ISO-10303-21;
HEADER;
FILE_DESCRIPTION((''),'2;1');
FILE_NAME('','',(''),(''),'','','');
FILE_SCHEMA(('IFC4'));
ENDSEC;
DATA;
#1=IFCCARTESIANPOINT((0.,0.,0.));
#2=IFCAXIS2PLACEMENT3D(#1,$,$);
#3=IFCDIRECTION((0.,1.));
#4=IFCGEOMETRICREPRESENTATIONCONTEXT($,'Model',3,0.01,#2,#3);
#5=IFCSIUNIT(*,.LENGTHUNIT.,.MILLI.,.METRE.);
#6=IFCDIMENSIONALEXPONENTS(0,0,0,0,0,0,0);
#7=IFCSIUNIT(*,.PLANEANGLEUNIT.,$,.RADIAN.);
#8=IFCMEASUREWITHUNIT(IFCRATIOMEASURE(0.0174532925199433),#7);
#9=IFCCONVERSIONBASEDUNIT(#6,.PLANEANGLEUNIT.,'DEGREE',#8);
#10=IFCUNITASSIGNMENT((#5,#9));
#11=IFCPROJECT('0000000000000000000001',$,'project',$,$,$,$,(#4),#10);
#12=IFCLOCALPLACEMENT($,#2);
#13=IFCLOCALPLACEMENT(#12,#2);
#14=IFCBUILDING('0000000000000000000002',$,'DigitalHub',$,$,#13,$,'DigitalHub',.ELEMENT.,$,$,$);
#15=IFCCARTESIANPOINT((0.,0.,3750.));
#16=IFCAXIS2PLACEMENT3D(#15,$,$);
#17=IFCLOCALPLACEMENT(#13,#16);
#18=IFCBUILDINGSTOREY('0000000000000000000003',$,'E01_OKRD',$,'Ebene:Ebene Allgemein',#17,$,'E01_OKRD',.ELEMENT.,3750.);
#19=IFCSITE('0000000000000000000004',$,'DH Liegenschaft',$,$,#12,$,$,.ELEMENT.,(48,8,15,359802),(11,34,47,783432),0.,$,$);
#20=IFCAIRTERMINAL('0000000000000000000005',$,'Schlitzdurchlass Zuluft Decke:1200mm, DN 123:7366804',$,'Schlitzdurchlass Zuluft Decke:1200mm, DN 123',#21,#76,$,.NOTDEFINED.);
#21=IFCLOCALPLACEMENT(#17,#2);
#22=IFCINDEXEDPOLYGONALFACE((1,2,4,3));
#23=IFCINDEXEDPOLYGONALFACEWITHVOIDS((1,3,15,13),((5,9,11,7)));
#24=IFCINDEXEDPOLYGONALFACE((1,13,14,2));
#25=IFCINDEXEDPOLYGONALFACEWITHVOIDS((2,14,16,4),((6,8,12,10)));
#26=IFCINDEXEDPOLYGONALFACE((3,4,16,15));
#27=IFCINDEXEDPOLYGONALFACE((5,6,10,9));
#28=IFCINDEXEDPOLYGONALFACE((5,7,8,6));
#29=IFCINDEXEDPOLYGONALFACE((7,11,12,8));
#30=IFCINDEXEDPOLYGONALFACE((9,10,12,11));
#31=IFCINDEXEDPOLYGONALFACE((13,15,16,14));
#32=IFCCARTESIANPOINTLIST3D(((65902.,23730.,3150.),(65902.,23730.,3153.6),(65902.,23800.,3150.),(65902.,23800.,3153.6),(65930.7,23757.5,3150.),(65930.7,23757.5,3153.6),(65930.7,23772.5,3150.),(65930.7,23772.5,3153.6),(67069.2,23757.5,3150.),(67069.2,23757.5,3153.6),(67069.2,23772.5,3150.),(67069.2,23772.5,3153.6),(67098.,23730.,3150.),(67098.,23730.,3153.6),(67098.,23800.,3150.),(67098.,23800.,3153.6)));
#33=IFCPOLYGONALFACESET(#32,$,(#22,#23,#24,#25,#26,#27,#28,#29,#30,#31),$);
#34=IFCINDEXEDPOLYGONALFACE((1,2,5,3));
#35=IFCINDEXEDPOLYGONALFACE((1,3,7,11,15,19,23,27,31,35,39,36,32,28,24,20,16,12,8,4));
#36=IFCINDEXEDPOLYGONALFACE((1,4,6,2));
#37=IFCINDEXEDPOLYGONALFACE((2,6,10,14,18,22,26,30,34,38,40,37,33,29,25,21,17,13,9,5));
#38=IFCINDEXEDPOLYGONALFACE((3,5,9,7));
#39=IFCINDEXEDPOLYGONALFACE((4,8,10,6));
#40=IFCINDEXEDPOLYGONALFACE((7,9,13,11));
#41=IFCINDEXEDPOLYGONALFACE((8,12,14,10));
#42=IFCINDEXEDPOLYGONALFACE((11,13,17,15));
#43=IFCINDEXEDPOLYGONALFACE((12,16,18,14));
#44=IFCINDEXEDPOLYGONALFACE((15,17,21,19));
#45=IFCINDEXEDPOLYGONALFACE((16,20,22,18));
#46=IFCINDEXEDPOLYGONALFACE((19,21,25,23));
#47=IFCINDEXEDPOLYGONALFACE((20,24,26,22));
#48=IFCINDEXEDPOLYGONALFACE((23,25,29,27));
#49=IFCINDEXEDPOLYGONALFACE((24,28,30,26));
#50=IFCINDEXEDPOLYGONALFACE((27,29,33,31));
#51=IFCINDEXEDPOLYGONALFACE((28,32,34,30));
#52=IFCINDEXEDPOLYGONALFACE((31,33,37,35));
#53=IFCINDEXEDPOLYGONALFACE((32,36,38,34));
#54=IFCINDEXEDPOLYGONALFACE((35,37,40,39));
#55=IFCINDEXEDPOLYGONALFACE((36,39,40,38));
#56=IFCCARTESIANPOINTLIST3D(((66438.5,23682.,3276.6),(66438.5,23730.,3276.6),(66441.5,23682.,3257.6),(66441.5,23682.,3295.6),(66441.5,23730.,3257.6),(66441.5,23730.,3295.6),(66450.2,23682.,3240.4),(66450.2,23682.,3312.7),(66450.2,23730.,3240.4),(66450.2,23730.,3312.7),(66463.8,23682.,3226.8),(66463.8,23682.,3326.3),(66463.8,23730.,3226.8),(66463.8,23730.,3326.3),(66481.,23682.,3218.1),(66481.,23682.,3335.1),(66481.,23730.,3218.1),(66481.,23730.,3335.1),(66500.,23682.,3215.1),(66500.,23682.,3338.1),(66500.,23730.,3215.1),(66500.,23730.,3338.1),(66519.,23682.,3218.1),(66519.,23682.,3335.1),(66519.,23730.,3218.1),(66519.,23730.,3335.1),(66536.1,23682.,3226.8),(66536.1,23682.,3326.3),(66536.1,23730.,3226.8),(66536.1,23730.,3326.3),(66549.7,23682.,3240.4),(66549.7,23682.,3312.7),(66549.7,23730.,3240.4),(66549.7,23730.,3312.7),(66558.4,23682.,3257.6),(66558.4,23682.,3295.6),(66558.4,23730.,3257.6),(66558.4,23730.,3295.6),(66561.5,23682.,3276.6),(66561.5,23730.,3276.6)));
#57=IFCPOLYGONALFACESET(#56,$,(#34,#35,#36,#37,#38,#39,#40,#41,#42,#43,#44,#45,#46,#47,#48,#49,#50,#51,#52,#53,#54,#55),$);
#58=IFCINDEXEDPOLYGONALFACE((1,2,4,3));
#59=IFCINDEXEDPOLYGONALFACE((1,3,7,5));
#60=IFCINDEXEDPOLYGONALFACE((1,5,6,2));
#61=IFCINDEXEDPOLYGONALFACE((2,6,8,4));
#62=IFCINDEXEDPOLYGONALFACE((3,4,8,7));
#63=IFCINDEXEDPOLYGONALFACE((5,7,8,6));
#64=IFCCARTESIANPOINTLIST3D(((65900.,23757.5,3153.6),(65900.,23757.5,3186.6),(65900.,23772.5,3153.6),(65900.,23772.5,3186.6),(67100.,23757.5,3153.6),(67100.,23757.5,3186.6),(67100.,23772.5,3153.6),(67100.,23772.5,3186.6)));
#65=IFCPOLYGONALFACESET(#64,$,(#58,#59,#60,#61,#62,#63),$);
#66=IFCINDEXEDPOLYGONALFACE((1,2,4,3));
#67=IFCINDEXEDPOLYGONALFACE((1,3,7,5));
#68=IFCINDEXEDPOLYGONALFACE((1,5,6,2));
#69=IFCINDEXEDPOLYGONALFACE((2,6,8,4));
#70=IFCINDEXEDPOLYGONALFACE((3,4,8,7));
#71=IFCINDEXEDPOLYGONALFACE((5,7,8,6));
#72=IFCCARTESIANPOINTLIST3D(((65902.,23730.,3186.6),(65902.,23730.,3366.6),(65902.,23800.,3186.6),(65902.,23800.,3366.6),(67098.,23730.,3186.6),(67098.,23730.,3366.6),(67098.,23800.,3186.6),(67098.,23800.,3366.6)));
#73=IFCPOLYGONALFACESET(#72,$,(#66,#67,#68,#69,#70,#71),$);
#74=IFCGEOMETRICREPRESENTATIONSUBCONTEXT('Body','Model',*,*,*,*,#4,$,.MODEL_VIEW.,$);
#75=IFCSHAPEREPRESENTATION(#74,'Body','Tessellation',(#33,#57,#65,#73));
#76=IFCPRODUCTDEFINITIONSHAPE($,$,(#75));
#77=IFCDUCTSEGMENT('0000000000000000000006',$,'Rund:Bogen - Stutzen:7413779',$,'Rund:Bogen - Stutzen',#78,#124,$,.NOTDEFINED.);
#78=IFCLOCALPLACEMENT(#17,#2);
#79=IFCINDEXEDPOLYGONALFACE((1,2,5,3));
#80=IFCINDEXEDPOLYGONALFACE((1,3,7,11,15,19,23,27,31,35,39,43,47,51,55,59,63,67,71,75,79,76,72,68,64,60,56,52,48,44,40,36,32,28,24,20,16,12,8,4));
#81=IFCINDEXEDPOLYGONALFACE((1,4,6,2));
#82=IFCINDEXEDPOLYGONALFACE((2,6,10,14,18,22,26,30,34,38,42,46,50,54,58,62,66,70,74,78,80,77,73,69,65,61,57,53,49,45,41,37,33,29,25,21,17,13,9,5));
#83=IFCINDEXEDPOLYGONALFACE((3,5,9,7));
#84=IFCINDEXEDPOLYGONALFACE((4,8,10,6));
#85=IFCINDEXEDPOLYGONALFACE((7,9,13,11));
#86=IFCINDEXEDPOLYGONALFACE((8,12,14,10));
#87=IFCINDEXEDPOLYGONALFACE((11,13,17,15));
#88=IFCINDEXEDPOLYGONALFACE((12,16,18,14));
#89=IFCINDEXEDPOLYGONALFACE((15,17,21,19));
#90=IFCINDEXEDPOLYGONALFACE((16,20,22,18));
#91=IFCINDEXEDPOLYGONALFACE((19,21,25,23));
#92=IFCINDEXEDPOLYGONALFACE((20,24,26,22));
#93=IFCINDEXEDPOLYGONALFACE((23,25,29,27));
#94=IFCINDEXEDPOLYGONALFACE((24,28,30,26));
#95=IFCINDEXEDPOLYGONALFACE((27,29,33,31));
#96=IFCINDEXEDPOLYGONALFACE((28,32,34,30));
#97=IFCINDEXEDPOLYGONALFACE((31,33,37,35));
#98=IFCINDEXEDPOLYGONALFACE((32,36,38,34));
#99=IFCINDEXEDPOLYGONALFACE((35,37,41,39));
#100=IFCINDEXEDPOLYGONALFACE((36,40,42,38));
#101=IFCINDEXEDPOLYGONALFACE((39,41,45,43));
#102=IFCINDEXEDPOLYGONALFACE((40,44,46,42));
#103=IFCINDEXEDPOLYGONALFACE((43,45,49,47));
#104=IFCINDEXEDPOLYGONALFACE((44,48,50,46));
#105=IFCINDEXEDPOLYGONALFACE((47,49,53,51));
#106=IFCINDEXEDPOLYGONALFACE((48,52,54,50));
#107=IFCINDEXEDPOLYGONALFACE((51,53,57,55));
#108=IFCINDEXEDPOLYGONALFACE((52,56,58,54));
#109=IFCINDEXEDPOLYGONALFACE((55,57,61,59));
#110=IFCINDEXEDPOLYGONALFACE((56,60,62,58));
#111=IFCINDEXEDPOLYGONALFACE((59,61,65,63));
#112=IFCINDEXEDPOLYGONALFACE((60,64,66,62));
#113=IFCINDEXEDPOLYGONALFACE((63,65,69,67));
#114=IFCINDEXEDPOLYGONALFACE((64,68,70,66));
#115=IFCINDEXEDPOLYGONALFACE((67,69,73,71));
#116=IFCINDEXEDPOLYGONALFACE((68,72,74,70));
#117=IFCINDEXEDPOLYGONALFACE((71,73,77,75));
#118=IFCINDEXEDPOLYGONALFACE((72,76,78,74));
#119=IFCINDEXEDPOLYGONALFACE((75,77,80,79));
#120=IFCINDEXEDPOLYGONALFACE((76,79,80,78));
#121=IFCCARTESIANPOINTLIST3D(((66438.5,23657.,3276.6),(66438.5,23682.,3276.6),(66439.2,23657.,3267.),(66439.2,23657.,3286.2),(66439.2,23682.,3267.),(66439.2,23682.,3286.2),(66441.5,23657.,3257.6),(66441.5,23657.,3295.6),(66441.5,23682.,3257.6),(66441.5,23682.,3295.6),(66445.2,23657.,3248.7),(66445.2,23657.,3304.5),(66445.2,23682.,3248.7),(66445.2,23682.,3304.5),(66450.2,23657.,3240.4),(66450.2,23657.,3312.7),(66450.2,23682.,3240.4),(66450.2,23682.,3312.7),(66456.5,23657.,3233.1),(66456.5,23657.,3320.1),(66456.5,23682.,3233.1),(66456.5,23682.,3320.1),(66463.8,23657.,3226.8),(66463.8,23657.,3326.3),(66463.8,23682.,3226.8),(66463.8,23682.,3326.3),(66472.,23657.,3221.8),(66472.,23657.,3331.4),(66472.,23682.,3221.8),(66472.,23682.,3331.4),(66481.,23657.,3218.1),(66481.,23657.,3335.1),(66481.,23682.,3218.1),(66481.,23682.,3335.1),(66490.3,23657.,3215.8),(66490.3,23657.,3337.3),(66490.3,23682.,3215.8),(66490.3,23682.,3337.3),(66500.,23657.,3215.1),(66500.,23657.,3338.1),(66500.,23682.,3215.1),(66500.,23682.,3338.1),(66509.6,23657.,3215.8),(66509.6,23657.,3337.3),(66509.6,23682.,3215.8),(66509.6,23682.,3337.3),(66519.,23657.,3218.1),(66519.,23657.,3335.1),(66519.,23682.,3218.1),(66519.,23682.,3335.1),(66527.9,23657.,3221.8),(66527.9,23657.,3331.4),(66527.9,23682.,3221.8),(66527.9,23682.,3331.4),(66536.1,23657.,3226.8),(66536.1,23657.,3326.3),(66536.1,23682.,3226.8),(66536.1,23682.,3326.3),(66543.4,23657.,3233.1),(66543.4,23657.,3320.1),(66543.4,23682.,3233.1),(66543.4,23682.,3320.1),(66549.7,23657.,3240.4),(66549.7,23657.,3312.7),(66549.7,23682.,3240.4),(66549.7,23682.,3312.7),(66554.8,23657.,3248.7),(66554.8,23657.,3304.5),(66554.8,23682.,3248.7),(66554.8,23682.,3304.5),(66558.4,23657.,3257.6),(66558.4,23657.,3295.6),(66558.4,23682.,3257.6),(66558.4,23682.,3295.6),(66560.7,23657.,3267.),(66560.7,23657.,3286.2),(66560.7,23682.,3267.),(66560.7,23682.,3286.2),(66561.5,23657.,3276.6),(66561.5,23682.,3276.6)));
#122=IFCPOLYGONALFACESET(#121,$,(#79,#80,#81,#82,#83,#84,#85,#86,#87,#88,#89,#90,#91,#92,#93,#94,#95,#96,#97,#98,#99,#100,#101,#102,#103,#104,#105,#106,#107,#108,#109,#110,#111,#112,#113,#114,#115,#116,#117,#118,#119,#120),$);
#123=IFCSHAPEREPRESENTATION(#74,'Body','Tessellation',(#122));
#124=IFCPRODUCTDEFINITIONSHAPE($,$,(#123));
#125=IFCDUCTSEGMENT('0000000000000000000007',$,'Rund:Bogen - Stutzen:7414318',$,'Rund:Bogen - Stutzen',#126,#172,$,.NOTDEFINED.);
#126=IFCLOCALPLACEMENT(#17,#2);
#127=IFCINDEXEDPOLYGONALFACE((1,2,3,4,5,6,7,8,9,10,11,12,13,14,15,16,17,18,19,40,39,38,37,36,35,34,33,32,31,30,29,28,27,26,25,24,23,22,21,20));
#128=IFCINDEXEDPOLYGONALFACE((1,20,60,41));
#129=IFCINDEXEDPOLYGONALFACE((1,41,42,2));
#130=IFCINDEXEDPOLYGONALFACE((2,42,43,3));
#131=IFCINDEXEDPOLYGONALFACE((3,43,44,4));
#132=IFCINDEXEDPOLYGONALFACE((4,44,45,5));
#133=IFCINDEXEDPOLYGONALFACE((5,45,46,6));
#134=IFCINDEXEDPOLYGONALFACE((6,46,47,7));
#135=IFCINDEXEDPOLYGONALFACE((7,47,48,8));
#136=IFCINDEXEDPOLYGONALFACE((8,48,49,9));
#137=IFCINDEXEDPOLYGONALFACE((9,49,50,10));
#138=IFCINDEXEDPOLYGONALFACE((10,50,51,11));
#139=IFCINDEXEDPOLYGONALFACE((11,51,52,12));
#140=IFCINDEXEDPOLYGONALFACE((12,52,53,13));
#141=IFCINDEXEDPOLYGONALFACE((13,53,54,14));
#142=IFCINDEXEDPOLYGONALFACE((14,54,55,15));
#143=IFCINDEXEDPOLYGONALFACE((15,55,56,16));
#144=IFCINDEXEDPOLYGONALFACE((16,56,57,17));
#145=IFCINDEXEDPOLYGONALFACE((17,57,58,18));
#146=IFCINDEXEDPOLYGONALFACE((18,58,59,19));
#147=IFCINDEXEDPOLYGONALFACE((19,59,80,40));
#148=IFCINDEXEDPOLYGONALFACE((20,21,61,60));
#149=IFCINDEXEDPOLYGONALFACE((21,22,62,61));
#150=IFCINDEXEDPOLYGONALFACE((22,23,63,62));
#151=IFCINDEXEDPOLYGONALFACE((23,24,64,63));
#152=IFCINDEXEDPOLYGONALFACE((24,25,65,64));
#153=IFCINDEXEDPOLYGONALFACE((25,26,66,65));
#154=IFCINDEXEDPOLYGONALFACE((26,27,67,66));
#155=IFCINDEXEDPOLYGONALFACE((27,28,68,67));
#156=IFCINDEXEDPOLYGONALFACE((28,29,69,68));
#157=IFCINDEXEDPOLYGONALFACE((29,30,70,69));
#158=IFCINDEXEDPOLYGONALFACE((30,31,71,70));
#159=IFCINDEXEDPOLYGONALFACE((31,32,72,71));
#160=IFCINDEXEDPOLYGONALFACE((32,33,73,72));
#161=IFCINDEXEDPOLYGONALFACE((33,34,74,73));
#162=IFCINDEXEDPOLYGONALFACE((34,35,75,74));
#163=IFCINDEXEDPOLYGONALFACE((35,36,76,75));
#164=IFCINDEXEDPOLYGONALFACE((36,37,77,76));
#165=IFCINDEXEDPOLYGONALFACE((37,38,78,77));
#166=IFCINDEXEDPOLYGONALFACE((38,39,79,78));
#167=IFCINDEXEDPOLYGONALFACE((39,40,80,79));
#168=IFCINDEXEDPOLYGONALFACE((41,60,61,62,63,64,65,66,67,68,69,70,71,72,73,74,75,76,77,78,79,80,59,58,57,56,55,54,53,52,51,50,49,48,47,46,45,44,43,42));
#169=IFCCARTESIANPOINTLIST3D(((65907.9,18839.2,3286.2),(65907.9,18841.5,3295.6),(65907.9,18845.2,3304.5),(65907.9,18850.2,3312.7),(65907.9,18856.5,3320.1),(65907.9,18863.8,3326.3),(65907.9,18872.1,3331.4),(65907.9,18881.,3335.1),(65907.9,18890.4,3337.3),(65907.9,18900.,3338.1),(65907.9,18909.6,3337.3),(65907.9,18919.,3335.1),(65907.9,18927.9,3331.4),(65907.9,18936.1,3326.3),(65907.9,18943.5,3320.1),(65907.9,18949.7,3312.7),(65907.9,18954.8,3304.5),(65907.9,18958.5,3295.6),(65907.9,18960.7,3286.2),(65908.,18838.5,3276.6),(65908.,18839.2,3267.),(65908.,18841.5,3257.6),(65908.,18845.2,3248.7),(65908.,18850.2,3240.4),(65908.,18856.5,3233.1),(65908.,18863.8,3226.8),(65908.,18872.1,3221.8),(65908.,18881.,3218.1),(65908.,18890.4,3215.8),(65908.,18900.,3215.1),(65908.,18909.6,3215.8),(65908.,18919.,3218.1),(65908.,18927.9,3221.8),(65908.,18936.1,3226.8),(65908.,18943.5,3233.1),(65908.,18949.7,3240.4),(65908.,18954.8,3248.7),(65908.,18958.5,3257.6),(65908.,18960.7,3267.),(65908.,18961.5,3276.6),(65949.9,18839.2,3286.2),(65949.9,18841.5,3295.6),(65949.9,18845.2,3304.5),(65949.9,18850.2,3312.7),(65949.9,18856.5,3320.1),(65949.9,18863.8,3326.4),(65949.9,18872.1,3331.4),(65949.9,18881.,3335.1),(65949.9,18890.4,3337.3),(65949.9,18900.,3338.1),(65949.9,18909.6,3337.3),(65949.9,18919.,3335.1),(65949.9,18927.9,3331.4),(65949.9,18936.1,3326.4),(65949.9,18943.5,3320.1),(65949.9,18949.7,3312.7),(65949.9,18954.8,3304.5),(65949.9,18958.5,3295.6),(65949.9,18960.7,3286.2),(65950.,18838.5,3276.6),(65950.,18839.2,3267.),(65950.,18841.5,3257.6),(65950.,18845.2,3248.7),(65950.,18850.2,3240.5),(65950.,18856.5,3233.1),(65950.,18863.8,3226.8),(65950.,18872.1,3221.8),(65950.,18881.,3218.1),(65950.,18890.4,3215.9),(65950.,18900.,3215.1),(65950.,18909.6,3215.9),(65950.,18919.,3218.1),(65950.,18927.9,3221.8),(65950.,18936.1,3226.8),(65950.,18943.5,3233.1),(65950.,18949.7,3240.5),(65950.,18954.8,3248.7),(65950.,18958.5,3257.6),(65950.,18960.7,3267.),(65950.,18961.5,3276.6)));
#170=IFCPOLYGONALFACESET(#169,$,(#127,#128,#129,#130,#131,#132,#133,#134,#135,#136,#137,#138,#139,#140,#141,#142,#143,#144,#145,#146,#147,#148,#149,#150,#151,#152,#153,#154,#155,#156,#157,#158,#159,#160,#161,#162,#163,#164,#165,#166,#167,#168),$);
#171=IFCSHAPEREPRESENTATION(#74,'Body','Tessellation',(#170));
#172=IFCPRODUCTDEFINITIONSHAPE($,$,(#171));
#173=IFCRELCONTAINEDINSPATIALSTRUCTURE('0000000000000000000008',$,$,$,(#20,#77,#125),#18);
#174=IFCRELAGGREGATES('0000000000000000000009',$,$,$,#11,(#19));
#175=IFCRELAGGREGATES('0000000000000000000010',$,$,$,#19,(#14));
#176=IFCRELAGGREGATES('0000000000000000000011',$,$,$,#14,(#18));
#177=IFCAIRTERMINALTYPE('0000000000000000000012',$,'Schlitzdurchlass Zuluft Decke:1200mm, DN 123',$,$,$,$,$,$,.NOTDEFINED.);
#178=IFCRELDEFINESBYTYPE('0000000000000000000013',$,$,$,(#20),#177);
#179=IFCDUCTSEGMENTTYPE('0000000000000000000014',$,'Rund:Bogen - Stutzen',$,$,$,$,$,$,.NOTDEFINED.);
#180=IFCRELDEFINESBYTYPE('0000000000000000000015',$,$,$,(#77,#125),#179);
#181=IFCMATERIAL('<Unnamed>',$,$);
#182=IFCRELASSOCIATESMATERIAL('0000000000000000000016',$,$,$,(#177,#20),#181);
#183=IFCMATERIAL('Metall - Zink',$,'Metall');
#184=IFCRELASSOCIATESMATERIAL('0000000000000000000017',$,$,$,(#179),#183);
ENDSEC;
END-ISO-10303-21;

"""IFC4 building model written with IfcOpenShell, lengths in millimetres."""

from ifc_helpers import new_model, entity, si_unit, converted_unit, direction, frame, origin, place, context, subcontext, project, spatial, indexed_curve, outline, extrude, source, transform, mapped, material, type_object, type_shapes, element, save


model = new_model("IFC4")

# Units and contexts
model_context = context("Model", 3, precision=0.01, world=origin(), true_north=direction((0.0, 1.0)))
body_context = subcontext(model_context, "Body", "Model", "MODEL_VIEW")
ifc_project = project(units=[si_unit("LENGTHUNIT", "METRE", prefix="MILLI"), converted_unit("PLANEANGLEUNIT", "DEGREE", entity("IfcRatioMeasure", 0.0174532925199433), si_unit("PLANEANGLEUNIT", "RADIAN"), dimensions=[0, 0, 0, 0, 0, 0, 0])], contexts=[model_context])

# Site, building, storey
site_placement = place(None, origin())
site = spatial("IfcSite", under=ifc_project, at=site_placement, Name="DH Liegenschaft", CompositionType="ELEMENT", RefLatitude=(48, 8, 15, 359802), RefLongitude=(11, 34, 47, 783432), RefElevation=0.0)
building_placement = place(site_placement, origin())
building = spatial("IfcBuilding", under=site, at=building_placement, Name="DigitalHub", LongName="DigitalHub", CompositionType="ELEMENT")
storey_placement = place(building_placement, frame((0.0, 0.0, 3750.0)))
storey = spatial("IfcBuildingStorey", under=building, at=storey_placement, Name="E01_OKRD", ObjectType="Ebene:Ebene Allgemein", LongName="E01_OKRD", CompositionType="ELEMENT", Elevation=3750.0)

# Shared definitions
ifc_material_1 = material(Name="Metall - Zink", Category="Metall")

# Air terminal
ifc_material_2 = material(Name="<Unnamed>")
air_terminal_type_1 = type_object("IfcAirTerminalType", Name="Schlitzdurchlass Zuluft Decke:1200mm, DN 123", PredefinedType="NOTDEFINED", material=ifc_material_2)
shared_shape_1 = source(origin(), body_context, "Body", "SweptSolid", [
    extrude(outline(indexed_curve([(-598.0, -35.0), (598.0, -35.0), (598.0, 35.0), (-598.0, 35.0), (-598.0, -35.0)], self_intersect=False), holes=[indexed_curve([(-569.2, -7.5), (-569.2, 7.5), (569.2, 7.5), (569.2, -7.5), (-569.2, -7.5)], self_intersect=False)]), frame((600.0, 35.0, 0.0), z_axis=(0.0, 0.0, 1.0), x_axis=(-1.0, 0.0, 0.0)), (0.0, 0.0, 1.0), 3.6),
    extrude(outline(indexed_curve([(61.5, 0.0), (58.5, 19.0), (49.8, 36.1), (36.1, 49.8), (19.0, 58.5), (0.0, 61.5), (-19.0, 58.5), (-36.1, 49.8), (-49.8, 36.1), (-58.5, 19.0), (-61.5, 0.0), (-58.5, -19.0), (-49.8, -36.1), (-36.1, -49.8), (-19.0, -58.5), (0.0, -61.5), (19.0, -58.5), (36.1, -49.8), (49.8, -36.1), (58.5, -19.0), (61.5, 0.0)], self_intersect=False)), frame((600.0, 70.0, 126.6), z_axis=(0.0, 1.0, 0.0), x_axis=(-1.0, 0.0, 0.0)), (0.0, 0.0, 1.0), 48.0),
    extrude(outline(indexed_curve([(-600.0, -7.5), (600.0, -7.5), (600.0, 7.5), (-600.0, 7.5), (-600.0, -7.5)], self_intersect=False)), frame((600.0, 35.0, 3.6), z_axis=(0.0, 0.0, 1.0), x_axis=(-1.0, 0.0, 0.0)), (0.0, 0.0, 1.0), 33.0),
    extrude(outline(indexed_curve([(-598.0, -35.0), (598.0, -35.0), (598.0, 35.0), (-598.0, 35.0), (-598.0, -35.0)], self_intersect=False)), frame((600.0, 35.0, 36.6), z_axis=(0.0, 0.0, 1.0), x_axis=(-1.0, 0.0, 0.0)), (0.0, 0.0, 1.0), 180.0),
])
type_shapes(air_terminal_type_1, [shared_shape_1])
air_terminal_placement = place(storey_placement, frame((67100.0, 23800.0, 3150.0), z_axis=(0.0, 0.0, 1.0), x_axis=(-1.0, 0.0, 0.0)))
element("IfcAirTerminal", 1, at=air_terminal_placement, inside=storey, type_object=air_terminal_type_1, material=ifc_material_2, Name="Schlitzdurchlass Zuluft Decke:1200mm, DN 123:7366804", ObjectType="Schlitzdurchlass Zuluft Decke:1200mm, DN 123", PredefinedType="NOTDEFINED", context=body_context, shape_type="MappedRepresentation", body=[
    mapped(shared_shape_1, transform((0.0, 0.0, 0.0), scale=1.0)),
])

# Duct segments
duct_segment_type_1 = type_object("IfcDuctSegmentType", Name="Rund:Bogen - Stutzen", PredefinedType="NOTDEFINED", material=ifc_material_1)
duct_segment_1_placement = place(storey_placement, frame((66436.9, 23657.0, 3213.5)))
element("IfcDuctSegment", 2, at=duct_segment_1_placement, inside=storey, type_object=duct_segment_type_1, Name="Rund:Bogen - Stutzen:7413779", ObjectType="Rund:Bogen - Stutzen", PredefinedType="NOTDEFINED", context=body_context, shape_type="SweptSolid", body=[
    extrude(outline(indexed_curve([(61.5, 0.0), (60.7, 9.6), (58.5, 19.0), (54.8, 27.9), (49.8, 36.1), (43.5, 43.5), (36.1, 49.8), (27.9, 54.8), (19.0, 58.5), (9.6, 60.7), (0.0, 61.5), (-9.6, 60.7), (-19.0, 58.5), (-27.9, 54.8), (-36.1, 49.8), (-43.5, 43.5), (-49.8, 36.1), (-54.8, 27.9), (-58.5, 19.0), (-60.7, 9.6), (-61.5, 0.0), (-60.7, -9.6), (-58.5, -19.0), (-54.8, -27.9), (-49.8, -36.1), (-43.5, -43.5), (-36.1, -49.8), (-27.9, -54.8), (-19.0, -58.5), (-9.6, -60.7), (0.0, -61.5), (9.6, -60.7), (19.0, -58.5), (27.9, -54.8), (36.1, -49.8), (43.5, -43.5), (49.8, -36.1), (54.8, -27.9), (58.5, -19.0), (60.7, -9.6), (61.5, 0.0)], self_intersect=False)), frame((63.1, 0.0, 63.1), z_axis=(0.0, 1.0, 0.0), x_axis=(-1.0, 0.0, 0.0)), (0.0, 0.0, 1.0), 25.0),
])
duct_segment_2_placement = place(storey_placement, frame((65907.9, 18836.9, 3213.5)))
element("IfcDuctSegment", 3, at=duct_segment_2_placement, inside=storey, type_object=duct_segment_type_1, Name="Rund:Bogen - Stutzen:7414318", ObjectType="Rund:Bogen - Stutzen", PredefinedType="NOTDEFINED", context=body_context, shape_type="SweptSolid", body=[
    extrude(outline(indexed_curve([(61.5, 0.0), (60.7, 9.6), (58.5, 19.0), (54.8, 27.9), (49.8, 36.1), (43.5, 43.5), (36.1, 49.8), (27.9, 54.8), (19.0, 58.5), (9.6, 60.7), (0.0, 61.5), (-9.6, 60.7), (-19.0, 58.5), (-27.9, 54.8), (-36.1, 49.8), (-43.5, 43.5), (-49.8, 36.1), (-54.8, 27.9), (-58.5, 19.0), (-60.7, 9.6), (-61.5, 0.0), (-60.7, -9.6), (-58.5, -19.0), (-54.8, -27.9), (-49.8, -36.1), (-43.5, -43.5), (-36.1, -49.8), (-27.9, -54.8), (-19.0, -58.5), (-9.6, -60.7), (0.0, -61.5), (9.6, -60.7), (19.0, -58.5), (27.9, -54.8), (36.1, -49.8), (43.5, -43.5), (49.8, -36.1), (54.8, -27.9), (58.5, -19.0), (60.7, -9.6), (61.5, 0.0)], self_intersect=False)), frame((0.0, 63.1, 63.1), z_axis=(1.0, 0.0, 0.000613), x_axis=(0.0, 1.0, 0.0)), (0.0, 0.0, 1.0), 42.0),
])

save(model, "model.ifc")
